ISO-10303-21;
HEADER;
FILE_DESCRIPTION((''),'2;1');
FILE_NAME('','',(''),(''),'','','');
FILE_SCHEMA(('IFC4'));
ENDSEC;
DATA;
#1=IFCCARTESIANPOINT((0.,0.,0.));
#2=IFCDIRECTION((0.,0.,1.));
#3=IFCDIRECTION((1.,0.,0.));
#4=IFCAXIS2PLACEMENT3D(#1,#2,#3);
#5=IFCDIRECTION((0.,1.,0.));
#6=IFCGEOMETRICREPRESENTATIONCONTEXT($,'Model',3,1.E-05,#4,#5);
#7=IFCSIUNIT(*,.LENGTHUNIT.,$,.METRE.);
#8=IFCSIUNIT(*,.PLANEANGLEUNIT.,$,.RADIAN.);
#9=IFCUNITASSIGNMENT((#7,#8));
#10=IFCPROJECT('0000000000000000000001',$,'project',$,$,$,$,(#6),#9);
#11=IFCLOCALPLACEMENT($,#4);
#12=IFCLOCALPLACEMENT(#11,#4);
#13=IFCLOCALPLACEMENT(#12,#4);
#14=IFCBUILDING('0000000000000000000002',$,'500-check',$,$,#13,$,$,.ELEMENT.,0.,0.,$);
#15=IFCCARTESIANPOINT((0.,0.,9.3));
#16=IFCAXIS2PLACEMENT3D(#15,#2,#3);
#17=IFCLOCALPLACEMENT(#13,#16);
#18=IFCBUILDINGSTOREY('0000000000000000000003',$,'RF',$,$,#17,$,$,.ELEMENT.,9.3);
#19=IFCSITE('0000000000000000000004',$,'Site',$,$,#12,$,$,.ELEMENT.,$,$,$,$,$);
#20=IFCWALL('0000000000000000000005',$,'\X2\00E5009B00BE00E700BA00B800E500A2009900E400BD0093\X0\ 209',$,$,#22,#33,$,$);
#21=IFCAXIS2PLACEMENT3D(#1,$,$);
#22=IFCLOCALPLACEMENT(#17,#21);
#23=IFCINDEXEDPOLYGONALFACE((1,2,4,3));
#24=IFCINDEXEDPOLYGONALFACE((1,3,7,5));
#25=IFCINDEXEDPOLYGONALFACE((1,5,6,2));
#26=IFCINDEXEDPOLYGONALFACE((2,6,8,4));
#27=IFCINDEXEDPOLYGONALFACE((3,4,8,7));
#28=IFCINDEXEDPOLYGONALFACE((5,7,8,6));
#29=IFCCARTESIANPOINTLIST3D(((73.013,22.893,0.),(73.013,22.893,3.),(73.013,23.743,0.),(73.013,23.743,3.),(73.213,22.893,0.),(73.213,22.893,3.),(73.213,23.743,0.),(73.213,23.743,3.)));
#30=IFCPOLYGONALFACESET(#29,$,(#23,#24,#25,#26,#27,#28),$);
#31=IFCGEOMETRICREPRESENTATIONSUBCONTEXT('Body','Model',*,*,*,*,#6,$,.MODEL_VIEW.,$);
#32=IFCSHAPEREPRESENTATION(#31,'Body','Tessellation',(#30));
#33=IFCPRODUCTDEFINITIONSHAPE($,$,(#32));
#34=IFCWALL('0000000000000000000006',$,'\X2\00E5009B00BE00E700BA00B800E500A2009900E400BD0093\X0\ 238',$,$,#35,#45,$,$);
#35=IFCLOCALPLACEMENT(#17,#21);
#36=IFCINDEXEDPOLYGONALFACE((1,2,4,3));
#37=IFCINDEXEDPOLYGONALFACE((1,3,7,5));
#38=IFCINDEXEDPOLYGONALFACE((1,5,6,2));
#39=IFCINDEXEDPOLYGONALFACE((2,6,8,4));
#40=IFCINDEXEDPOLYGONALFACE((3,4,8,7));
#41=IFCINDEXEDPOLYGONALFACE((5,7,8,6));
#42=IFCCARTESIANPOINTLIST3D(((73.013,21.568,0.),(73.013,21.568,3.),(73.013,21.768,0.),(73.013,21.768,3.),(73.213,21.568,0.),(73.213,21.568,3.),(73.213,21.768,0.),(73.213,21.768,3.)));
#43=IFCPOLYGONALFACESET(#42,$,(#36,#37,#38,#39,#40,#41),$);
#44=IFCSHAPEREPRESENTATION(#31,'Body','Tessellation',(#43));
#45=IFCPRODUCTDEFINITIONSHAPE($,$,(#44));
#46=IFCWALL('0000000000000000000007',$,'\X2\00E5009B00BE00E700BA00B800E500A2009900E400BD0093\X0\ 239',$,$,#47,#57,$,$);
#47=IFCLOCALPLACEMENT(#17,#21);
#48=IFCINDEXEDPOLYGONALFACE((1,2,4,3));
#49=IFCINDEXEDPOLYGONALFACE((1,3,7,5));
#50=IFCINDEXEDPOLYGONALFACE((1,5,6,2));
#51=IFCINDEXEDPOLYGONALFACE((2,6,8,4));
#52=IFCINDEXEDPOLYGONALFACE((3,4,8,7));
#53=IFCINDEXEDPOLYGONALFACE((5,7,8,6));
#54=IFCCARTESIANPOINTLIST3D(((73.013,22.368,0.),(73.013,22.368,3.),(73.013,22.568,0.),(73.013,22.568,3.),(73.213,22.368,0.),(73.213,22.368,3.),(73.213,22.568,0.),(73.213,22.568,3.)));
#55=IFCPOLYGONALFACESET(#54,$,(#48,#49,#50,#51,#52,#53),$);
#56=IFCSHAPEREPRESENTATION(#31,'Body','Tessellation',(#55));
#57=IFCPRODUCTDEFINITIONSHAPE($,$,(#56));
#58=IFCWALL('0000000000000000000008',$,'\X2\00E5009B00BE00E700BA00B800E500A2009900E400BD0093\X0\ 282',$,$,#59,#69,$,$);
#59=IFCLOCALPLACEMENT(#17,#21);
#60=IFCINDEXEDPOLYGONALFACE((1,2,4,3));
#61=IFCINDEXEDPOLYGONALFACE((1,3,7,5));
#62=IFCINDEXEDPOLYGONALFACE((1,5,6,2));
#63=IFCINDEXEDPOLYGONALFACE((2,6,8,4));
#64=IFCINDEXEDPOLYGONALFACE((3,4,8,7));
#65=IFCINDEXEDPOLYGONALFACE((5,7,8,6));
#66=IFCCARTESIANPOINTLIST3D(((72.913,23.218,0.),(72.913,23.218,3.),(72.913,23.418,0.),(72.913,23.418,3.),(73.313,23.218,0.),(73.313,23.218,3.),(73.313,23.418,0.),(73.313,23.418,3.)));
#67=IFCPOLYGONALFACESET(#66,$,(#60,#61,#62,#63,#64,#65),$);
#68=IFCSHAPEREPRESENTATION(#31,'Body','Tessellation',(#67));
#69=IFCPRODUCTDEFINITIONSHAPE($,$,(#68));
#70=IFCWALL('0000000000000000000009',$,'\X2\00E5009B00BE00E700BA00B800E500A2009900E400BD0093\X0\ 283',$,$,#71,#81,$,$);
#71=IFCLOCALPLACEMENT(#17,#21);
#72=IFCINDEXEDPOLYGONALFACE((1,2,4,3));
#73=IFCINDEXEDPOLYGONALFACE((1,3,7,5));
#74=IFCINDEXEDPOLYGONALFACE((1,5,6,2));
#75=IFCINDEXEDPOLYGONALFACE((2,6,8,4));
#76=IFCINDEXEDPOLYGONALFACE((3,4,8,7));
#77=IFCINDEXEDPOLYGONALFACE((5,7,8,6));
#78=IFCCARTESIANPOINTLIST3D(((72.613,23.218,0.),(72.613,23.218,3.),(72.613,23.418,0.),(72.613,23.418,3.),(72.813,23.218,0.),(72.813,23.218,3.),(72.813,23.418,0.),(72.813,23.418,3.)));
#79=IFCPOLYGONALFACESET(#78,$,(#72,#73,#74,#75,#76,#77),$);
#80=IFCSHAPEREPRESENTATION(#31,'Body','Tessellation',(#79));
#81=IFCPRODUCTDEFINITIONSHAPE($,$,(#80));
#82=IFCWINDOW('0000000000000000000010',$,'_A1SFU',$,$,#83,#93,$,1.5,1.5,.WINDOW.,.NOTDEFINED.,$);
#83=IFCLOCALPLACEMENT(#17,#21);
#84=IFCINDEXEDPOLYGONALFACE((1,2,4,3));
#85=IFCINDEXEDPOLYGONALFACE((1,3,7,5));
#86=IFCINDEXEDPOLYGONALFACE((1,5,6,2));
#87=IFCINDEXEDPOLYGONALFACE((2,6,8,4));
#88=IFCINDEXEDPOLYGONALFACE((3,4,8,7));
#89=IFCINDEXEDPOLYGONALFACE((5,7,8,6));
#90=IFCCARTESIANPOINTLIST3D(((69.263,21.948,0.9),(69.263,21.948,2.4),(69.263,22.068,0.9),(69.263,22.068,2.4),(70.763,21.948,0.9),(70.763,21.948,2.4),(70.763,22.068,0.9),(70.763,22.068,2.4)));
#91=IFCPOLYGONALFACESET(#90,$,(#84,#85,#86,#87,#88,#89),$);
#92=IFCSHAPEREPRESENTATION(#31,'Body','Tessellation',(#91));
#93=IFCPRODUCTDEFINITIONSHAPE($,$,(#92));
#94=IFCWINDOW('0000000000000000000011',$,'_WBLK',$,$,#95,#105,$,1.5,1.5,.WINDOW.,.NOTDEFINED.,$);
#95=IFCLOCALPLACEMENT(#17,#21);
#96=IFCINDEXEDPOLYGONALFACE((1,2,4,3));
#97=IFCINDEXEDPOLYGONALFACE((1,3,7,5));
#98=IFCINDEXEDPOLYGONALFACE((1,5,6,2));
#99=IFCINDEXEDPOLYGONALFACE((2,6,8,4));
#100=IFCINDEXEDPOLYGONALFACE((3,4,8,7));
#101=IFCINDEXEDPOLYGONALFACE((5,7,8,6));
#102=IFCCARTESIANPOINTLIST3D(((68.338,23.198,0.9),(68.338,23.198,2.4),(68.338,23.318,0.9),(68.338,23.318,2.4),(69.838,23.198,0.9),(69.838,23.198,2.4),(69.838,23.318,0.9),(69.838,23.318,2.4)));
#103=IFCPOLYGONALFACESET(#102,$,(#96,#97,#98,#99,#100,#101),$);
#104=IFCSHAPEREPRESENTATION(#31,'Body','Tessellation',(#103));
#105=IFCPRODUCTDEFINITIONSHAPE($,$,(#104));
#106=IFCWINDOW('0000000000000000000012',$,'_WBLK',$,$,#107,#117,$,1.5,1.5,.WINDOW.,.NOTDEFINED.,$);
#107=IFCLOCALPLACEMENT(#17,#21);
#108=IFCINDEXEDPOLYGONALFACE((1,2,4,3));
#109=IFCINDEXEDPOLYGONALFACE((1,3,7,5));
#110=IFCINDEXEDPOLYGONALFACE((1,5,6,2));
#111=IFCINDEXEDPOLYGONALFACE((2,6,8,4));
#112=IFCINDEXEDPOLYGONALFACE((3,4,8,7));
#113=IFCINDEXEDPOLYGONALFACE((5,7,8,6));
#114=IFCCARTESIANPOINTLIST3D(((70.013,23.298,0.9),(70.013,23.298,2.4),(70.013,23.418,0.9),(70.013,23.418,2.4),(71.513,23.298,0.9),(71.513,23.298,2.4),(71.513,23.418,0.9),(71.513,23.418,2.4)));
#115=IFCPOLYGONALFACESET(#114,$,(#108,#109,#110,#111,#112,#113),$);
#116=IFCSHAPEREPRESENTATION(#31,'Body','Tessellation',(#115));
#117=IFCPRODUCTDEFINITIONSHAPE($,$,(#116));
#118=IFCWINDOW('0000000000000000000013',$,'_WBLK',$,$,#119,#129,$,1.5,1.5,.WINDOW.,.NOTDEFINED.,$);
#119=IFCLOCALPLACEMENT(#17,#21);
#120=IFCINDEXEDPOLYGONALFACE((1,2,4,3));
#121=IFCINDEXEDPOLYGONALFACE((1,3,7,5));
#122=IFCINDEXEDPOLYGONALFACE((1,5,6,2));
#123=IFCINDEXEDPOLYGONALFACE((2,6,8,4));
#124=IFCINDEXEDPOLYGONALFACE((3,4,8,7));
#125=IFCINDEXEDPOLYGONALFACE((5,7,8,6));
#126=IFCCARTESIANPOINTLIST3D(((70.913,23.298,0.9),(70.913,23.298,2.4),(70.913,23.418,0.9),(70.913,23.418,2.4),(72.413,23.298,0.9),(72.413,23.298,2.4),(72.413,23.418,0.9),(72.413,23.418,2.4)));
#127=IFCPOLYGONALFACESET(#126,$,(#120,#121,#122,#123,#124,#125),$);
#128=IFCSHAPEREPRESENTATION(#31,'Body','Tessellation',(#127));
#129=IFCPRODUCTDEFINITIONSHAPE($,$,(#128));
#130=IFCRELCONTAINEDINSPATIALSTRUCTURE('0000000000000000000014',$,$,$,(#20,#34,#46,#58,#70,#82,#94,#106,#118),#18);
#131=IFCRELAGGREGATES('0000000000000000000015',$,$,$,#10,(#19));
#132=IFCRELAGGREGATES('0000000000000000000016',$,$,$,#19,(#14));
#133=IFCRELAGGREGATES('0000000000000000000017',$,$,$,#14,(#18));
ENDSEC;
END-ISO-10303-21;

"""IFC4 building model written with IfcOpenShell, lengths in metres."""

from ifc_helpers import new_model, si_unit, direction, frame, frame_2d, origin_with_axes, place, context, subcontext, project, spatial, rectangle, extrude, element, save


model = new_model("IFC4")

# Units and contexts
model_context = context("Model", 3, precision=1e-05, world=origin_with_axes(), true_north=direction((0.0, 1.0, 0.0)))
body_context = subcontext(model_context, "Body", "Model", "MODEL_VIEW")
ifc_project = project(units=[si_unit("LENGTHUNIT", "METRE"), si_unit("PLANEANGLEUNIT", "RADIAN")], contexts=[model_context])

# Site, building, storey
placement = place(None, origin_with_axes())
site_placement = place(placement, origin_with_axes())
site = spatial("IfcSite", under=ifc_project, at=site_placement, Name="Site", CompositionType="ELEMENT")
building_placement = place(site_placement, origin_with_axes())
building = spatial("IfcBuilding", under=site, at=building_placement, Name="500-check", CompositionType="ELEMENT", ElevationOfRefHeight=0.0, ElevationOfTerrain=0.0)
storey_placement = place(building_placement, frame((0.0, 0.0, 9.3), z_axis=(0.0, 0.0, 1.0), x_axis=(1.0, 0.0, 0.0)))
storey = spatial("IfcBuildingStorey", under=building, at=storey_placement, Name="RF", CompositionType="ELEMENT", Elevation=9.3)

# Walls
for number, where, z_axis, x_axis, name in (
    (1, (73.113, 23.318, 0.0), (0.0, 0.0, 1.0), (0.0, -1.0, 0.0), "å\u009b¾çº¸å¢\u0099ä½\u0093 209"),
):
    element("IfcWall", number, at=place(storey_placement, frame(where, z_axis=z_axis, x_axis=x_axis)), inside=storey, Name=name, context=body_context, shape_type="SweptSolid", body=[
        extrude(rectangle(XDim=0.85, YDim=0.2, at=frame_2d((0.0, 0.0), x_axis=(1.0, 0.0, 0.0))), frame((0.0, 0.0, 0.0), z_axis=(0.0, 0.0, 1.0)), (0.0, 0.0, 1.0), 3.0),
    ])
for number, where, z_axis, x_axis, name in (
    (2, (73.113, 21.668, 0.0), (0.0, 0.0, 1.0), (0.0, -1.0, 0.0), "å\u009b¾çº¸å¢\u0099ä½\u0093 238"),
    (3, (73.113, 22.468, 0.0), (0.0, 0.0, 1.0), (1.0, 0.0, 0.0), "å\u009b¾çº¸å¢\u0099ä½\u0093 239"),
):
    element("IfcWall", number, at=place(storey_placement, frame(where, z_axis=z_axis, x_axis=x_axis)), inside=storey, Name=name, context=body_context, shape_type="SweptSolid", body=[
        extrude(rectangle(XDim=0.2, YDim=0.2, at=frame_2d((0.0, 0.0), x_axis=(1.0, 0.0, 0.0))), frame((0.0, 0.0, 0.0), z_axis=(0.0, 0.0, 1.0)), (0.0, 0.0, 1.0), 3.0),
    ])
wall_1_placement = place(storey_placement, frame((73.113, 23.318, 0.0), z_axis=(0.0, 0.0, 1.0), x_axis=(-1.0, 0.0, 0.0)))
element("IfcWall", 4, at=wall_1_placement, inside=storey, Name="å\u009b¾çº¸å¢\u0099ä½\u0093 282", context=body_context, shape_type="SweptSolid", body=[
    extrude(rectangle(XDim=0.4, YDim=0.2, at=frame_2d((0.0, 0.0), x_axis=(1.0, 0.0, 0.0))), frame((0.0, 0.0, 0.0), z_axis=(0.0, 0.0, 1.0)), (0.0, 0.0, 1.0), 3.0),
])
for number, where, z_axis, x_axis, name in (
    (5, (72.713, 23.318, 0.0), (0.0, 0.0, 1.0), (0.0, 1.0, 0.0), "å\u009b¾çº¸å¢\u0099ä½\u0093 283"),
):
    element("IfcWall", number, at=place(storey_placement, frame(where, z_axis=z_axis, x_axis=x_axis)), inside=storey, Name=name, context=body_context, shape_type="SweptSolid", body=[
        extrude(rectangle(XDim=0.2, YDim=0.2, at=frame_2d((0.0, 0.0), x_axis=(1.0, 0.0, 0.0))), frame((0.0, 0.0, 0.0), z_axis=(0.0, 0.0, 1.0)), (0.0, 0.0, 1.0), 3.0),
    ])

# Windows
for number, where, z_axis, x_axis, name in (
    (6, (70.013, 22.008, 0.9), (0.0, 0.0, 1.0), (1.0, 0.0, 0.0), "_A1SFU"),
    (7, (69.088, 23.258, 0.9), (0.0, 0.0, 1.0), (1.0, 0.0, 0.0), "_WBLK"),
    (8, (70.763, 23.358, 0.9), (0.0, 0.0, 1.0), (1.0, 0.0, 0.0), "_WBLK"),
    (9, (71.663, 23.358, 0.9), (0.0, 0.0, 1.0), (1.0, 0.0, 0.0), "_WBLK"),
):
    element("IfcWindow", number, at=place(storey_placement, frame(where, z_axis=z_axis, x_axis=x_axis)), inside=storey, Name=name, OverallHeight=1.5, OverallWidth=1.5, PartitioningType="NOTDEFINED", PredefinedType="WINDOW", context=body_context, shape_type="SweptSolid", body=[
        extrude(rectangle(XDim=1.5, YDim=0.12, at=frame_2d((0.0, 0.0), x_axis=(1.0, 0.0, 0.0))), frame((0.0, 0.0, 0.0), z_axis=(0.0, 0.0, 1.0)), (0.0, 0.0, 1.0), 1.5),
    ])

save(model, "model.ifc")
